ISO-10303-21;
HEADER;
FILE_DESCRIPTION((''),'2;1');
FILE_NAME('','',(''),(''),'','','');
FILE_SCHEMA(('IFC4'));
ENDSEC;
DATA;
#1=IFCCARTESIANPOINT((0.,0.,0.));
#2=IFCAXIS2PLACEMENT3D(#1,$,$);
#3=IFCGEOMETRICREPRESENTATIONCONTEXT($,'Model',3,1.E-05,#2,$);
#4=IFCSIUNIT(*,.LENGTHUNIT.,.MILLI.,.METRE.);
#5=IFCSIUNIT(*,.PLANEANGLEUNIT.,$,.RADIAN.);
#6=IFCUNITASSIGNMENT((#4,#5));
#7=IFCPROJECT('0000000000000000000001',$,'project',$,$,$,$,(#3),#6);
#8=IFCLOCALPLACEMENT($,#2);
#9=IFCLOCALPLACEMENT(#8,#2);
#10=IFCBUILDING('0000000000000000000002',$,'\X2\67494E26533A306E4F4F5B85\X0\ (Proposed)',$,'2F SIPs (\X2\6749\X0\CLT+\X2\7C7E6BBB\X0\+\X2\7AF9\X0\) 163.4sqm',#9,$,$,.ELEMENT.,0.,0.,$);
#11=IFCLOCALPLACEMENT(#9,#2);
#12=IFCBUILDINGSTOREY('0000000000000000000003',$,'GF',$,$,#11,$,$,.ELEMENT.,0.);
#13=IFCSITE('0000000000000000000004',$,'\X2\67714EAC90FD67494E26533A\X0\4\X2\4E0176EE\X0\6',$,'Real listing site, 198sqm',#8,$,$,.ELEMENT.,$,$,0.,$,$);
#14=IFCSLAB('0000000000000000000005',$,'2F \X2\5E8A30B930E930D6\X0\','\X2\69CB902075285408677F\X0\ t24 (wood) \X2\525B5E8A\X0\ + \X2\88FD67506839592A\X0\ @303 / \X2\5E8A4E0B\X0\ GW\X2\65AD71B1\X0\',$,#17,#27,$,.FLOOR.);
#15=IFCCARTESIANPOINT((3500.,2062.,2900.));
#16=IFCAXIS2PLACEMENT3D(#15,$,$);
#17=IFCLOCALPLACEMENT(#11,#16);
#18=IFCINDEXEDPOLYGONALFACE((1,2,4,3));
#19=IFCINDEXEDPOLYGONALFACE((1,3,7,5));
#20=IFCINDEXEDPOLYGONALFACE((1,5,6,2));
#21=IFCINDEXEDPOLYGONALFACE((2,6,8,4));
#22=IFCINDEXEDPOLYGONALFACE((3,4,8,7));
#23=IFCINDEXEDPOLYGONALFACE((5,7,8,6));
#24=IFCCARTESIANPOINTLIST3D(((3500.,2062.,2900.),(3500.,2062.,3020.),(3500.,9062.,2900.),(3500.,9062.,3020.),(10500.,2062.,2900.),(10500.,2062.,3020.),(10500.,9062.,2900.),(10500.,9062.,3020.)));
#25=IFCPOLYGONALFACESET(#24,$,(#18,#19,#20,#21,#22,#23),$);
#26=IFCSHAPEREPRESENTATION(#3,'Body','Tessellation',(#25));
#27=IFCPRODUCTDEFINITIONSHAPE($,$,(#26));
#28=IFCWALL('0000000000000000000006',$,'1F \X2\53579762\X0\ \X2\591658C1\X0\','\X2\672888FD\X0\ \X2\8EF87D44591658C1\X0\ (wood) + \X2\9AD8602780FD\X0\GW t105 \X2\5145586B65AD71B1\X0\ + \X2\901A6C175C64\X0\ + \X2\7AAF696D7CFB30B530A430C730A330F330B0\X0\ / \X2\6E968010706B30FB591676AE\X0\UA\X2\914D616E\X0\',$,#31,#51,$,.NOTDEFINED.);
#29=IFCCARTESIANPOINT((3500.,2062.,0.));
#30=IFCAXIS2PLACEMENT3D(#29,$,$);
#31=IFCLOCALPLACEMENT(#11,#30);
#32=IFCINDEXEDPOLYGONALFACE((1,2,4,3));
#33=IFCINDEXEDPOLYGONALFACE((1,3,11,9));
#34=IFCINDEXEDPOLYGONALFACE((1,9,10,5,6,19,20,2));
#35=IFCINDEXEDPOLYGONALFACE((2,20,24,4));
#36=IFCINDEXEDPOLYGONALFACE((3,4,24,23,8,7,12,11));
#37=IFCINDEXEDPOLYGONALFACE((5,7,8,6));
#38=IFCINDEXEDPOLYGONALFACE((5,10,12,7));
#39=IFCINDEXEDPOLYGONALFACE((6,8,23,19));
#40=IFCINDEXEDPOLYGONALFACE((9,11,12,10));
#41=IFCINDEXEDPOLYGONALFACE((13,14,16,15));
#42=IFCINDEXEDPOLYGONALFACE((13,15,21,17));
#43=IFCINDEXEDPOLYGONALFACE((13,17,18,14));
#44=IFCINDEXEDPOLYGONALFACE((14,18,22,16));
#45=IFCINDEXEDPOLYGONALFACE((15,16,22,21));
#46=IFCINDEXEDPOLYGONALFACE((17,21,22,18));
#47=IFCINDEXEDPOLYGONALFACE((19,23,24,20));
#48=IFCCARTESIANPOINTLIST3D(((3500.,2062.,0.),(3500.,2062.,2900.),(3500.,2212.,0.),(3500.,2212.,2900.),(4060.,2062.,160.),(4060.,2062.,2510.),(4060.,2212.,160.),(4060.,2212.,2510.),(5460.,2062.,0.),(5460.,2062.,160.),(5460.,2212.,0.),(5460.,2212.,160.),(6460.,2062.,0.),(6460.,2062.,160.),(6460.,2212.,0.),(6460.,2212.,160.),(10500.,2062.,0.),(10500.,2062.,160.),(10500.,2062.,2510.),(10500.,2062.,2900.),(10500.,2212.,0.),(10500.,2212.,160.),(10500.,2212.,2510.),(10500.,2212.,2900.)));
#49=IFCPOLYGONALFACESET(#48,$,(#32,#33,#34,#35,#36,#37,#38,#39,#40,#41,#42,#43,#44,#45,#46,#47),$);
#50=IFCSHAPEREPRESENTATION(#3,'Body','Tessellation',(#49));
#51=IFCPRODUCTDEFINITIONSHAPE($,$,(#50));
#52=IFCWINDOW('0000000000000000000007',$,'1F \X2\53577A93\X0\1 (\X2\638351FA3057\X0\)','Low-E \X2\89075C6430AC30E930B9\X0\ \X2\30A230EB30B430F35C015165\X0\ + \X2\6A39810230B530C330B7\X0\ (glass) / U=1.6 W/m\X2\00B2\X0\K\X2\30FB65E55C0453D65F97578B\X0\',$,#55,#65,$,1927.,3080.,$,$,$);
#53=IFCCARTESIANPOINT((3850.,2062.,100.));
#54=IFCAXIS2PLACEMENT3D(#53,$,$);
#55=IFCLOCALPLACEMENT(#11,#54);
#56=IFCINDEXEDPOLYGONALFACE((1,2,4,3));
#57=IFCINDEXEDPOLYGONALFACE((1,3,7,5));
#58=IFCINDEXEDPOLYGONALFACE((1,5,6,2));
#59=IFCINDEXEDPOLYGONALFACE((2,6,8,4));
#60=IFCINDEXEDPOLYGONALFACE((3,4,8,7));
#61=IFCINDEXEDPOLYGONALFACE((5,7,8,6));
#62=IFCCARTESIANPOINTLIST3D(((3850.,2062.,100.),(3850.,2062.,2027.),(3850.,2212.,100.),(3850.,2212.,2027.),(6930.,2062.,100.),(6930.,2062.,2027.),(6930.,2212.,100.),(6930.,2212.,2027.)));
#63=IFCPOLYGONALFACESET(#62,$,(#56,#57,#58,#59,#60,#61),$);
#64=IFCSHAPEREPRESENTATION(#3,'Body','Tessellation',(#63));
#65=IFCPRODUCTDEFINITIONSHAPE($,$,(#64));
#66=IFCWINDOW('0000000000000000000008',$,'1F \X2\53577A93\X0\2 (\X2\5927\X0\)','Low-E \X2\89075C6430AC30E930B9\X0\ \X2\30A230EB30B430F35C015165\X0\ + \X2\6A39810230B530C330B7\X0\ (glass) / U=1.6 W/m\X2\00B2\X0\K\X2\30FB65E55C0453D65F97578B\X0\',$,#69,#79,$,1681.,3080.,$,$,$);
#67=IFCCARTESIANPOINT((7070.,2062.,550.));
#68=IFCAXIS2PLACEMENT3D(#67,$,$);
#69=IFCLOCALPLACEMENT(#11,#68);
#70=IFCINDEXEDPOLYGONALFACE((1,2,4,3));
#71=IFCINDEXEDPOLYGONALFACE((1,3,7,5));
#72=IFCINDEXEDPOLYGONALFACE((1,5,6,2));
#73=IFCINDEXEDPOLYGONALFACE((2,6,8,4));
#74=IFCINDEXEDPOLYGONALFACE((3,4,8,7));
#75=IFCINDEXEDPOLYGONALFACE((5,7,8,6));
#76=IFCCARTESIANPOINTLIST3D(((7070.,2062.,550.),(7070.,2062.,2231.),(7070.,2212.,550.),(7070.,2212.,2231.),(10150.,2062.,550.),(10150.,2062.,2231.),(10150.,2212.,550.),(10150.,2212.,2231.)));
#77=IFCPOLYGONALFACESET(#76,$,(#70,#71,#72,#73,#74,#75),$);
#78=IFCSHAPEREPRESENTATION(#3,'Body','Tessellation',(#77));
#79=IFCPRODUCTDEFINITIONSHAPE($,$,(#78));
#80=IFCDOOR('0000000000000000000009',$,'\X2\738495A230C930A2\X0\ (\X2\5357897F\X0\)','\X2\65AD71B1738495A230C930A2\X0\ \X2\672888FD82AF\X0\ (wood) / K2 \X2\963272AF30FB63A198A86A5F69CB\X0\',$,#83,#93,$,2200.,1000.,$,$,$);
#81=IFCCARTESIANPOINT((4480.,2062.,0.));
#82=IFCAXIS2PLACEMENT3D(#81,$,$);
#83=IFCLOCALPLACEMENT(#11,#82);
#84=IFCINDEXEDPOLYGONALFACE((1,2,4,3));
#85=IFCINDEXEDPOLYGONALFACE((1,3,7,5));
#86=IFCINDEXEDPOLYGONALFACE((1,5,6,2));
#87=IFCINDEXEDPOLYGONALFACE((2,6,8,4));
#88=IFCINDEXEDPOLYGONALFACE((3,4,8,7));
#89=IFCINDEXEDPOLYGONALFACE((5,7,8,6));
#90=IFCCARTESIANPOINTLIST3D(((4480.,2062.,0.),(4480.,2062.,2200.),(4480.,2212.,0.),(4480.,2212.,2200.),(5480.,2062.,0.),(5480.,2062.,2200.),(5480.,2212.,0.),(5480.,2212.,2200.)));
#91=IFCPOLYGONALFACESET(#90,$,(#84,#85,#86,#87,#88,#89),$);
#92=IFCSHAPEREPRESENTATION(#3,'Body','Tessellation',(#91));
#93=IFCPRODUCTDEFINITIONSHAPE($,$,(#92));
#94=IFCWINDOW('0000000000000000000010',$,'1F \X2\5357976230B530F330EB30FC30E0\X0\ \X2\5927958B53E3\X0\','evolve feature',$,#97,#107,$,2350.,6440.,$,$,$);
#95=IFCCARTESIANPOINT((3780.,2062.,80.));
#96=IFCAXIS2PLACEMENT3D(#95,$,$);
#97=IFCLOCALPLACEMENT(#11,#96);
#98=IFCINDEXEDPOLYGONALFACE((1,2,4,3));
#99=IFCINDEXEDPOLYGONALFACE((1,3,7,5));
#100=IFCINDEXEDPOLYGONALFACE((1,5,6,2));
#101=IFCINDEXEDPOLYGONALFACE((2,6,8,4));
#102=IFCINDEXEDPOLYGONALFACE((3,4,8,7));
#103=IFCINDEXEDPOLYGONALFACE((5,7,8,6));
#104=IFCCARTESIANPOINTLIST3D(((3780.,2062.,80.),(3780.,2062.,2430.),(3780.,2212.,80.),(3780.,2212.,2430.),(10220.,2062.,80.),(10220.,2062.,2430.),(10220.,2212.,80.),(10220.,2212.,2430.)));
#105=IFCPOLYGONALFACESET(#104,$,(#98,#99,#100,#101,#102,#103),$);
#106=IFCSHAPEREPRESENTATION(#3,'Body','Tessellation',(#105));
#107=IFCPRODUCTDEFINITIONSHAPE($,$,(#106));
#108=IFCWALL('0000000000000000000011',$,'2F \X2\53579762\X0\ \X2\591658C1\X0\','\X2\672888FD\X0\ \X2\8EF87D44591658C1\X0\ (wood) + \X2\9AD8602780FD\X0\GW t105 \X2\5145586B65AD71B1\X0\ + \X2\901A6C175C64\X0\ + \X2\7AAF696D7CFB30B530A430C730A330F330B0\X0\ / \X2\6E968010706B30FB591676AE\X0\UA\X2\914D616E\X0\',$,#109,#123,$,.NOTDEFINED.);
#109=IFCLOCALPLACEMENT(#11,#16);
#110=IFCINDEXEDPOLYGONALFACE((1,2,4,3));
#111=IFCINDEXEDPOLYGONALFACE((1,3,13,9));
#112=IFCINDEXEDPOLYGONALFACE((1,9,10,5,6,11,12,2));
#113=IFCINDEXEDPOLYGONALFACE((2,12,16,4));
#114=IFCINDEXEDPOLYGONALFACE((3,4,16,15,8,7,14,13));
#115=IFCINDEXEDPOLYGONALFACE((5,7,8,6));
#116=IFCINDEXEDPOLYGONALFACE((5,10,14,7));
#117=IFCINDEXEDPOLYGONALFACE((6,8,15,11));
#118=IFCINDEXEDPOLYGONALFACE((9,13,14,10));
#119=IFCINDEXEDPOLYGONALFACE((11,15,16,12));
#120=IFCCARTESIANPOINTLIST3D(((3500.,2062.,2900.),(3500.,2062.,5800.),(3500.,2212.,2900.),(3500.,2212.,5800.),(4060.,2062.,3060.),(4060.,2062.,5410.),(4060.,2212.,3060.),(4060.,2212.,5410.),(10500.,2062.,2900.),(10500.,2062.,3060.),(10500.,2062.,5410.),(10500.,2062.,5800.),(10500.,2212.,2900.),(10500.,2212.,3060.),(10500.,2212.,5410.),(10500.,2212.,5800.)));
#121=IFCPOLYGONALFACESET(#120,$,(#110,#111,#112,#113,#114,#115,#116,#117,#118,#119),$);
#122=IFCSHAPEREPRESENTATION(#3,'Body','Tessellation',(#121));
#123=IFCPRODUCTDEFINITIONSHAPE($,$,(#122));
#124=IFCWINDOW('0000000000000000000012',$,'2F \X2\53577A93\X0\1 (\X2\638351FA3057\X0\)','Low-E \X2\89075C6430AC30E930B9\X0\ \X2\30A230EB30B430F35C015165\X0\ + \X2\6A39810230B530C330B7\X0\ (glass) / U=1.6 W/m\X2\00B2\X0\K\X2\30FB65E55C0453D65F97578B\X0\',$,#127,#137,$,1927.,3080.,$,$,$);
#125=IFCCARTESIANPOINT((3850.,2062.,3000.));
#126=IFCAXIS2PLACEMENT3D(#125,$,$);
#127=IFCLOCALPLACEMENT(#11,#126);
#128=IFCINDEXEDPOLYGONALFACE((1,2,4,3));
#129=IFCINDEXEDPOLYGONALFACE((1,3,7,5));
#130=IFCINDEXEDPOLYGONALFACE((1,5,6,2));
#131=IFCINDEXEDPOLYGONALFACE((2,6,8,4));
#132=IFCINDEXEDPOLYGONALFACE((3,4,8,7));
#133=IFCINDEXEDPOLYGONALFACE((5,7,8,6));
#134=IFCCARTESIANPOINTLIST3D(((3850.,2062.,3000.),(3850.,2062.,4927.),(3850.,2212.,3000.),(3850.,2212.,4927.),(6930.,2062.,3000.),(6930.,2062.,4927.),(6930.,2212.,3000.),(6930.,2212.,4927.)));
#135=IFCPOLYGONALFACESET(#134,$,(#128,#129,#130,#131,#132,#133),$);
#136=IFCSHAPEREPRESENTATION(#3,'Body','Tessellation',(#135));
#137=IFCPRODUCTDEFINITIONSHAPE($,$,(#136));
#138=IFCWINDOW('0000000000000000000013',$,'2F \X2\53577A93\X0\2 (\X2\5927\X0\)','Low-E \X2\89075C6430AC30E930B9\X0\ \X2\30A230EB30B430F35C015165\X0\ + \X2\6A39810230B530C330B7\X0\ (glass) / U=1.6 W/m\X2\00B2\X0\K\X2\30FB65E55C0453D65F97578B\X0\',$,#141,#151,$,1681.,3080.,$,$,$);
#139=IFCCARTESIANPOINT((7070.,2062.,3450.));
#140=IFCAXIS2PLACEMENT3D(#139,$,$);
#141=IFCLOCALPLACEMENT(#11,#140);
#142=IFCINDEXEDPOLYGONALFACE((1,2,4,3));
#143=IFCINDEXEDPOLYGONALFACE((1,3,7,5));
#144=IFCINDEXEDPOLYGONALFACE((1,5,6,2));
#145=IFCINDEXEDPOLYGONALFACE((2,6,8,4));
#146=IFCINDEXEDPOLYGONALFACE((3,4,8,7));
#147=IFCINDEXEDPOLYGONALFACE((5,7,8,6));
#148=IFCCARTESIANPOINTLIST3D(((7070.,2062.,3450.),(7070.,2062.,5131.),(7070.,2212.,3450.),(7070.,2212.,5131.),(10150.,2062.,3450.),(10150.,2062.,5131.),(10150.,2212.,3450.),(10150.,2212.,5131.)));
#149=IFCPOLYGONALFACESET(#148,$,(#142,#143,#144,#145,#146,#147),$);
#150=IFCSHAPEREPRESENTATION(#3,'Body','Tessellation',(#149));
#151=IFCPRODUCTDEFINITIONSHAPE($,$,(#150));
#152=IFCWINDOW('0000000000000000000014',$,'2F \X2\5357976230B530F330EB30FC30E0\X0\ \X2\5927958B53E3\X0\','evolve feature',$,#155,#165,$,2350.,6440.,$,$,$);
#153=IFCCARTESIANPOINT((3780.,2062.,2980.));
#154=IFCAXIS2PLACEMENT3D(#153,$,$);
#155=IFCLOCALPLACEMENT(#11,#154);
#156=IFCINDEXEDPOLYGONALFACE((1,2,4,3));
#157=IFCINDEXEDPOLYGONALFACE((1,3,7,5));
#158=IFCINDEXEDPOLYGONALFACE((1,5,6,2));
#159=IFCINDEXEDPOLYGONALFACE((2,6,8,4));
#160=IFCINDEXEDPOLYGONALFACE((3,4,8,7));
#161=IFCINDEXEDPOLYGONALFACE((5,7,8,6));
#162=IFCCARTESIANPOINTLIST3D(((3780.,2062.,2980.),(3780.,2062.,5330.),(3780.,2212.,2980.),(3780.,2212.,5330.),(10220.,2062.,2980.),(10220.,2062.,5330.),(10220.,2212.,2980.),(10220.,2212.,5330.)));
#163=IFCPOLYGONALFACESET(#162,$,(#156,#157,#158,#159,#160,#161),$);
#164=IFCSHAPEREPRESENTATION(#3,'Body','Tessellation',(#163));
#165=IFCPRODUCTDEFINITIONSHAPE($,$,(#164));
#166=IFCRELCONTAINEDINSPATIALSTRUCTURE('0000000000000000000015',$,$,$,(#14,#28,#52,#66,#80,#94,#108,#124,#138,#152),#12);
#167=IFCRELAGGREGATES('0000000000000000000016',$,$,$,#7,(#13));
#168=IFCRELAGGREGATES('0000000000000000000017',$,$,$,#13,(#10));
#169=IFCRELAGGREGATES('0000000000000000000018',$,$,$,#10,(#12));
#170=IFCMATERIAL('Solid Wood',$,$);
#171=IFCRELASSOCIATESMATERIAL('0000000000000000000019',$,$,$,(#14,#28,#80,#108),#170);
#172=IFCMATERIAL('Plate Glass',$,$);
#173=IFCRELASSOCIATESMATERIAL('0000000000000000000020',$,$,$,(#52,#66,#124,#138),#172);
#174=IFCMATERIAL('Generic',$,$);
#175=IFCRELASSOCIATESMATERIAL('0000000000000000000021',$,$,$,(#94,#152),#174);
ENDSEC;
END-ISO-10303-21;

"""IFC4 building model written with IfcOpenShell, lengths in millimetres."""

from ifc_helpers import new_model, si_unit, frame, frame_2d, origin, place, context, project, spatial, rectangle, extrude, material, element, fill, save


model = new_model("IFC4")

# Units and contexts
model_context = context("Model", 3, precision=1e-05, world=origin())
ifc_project = project(units=[si_unit("LENGTHUNIT", "METRE", prefix="MILLI"), si_unit("PLANEANGLEUNIT", "RADIAN")], contexts=[model_context])

# Site, building, storey
site_placement = place(None, origin())
site = spatial("IfcSite", under=ifc_project, at=site_placement, Name="東京都杉並区4丁目6", ObjectType="Real listing site, 198sqm", CompositionType="ELEMENT", RefElevation=0.0)
building_placement = place(site_placement, origin())
building = spatial("IfcBuilding", under=site, at=building_placement, Name="杉並区の住宅 (Proposed)", ObjectType="2F SIPs (杉CLT+籾殻+竹) 163.4sqm", CompositionType="ELEMENT", ElevationOfRefHeight=0.0, ElevationOfTerrain=0.0)
storey_placement = place(building_placement, origin())
storey = spatial("IfcBuildingStorey", under=building, at=storey_placement, Name="GF", CompositionType="ELEMENT", Elevation=0.0)

# Slab
ifc_material_1 = material(Name="Solid Wood")
slab_1_placement = place(storey_placement, frame((3500.0, 2062.0, 2900.0)))
element("IfcSlab", 1, at=slab_1_placement, inside=storey, material=ifc_material_1, Name="2F 床スラブ", Description="構造用合板 t24 (wood) 剛床 + 製材根太 @303 / 床下 GW断熱", PredefinedType="FLOOR", context=model_context, shape_type="SweptSolid", body=[
    extrude(rectangle(XDim=7000.0, YDim=7000.0, at=frame_2d((3500.0, 3500.0))), frame((3500.0, 2062.0, 2900.0)), (0.0, 0.0, 1.0), 120.0),
])
ifc_material_2 = material(Name="Generic")

# Wall, openings, windows, door
wall_1_placement = place(storey_placement, frame((3500.0, 2062.0, 0.0)))
wall_1 = element("IfcWall", 2, at=wall_1_placement, inside=storey, material=ifc_material_1, Name="1F 南面 外壁", Description="木製 軸組外壁 (wood) + 高性能GW t105 充填断熱 + 通気層 + 窯業系サイディング / 準耐火・外皮UA配慮", PredefinedType="NOTDEFINED", context=model_context, shape_type="SweptSolid", body=[
    extrude(rectangle(XDim=7000.0, YDim=150.0, at=frame_2d((3500.0, 75.0))), frame((3500.0, 2062.0, 0.0)), (0.0, 0.0, 1.0), 2900.0),
])
opening_1_placement = place(storey_placement, frame((3850.0, 2062.0, 100.0)))
opening_1 = element("IfcOpeningElement", 3, at=opening_1_placement, cuts=wall_1, PredefinedType="NOTDEFINED", context=model_context, shape_type="SweptSolid", body=[
    extrude(rectangle(XDim=3080.0, YDim=150.0, at=frame_2d((1540.0, 75.0))), frame((3850.0, 2062.0, 100.0)), (0.0, 0.0, 1.0), 1927.0),
])
opening_2_placement = place(storey_placement, frame((7070.0, 2062.0, 550.0)))
opening_2 = element("IfcOpeningElement", 4, at=opening_2_placement, cuts=wall_1, PredefinedType="NOTDEFINED", context=model_context, shape_type="SweptSolid", body=[
    extrude(rectangle(XDim=3080.0, YDim=150.0, at=frame_2d((1540.0, 75.0))), frame((7070.0, 2062.0, 550.0)), (0.0, 0.0, 1.0), 1681.0),
])
opening_3_placement = place(storey_placement, frame((4480.0, 2062.0, 0.0)))
opening_3 = element("IfcOpeningElement", 5, at=opening_3_placement, cuts=wall_1, PredefinedType="NOTDEFINED", context=model_context, shape_type="SweptSolid", body=[
    extrude(rectangle(XDim=1000.0, YDim=150.0, at=frame_2d((500.0, 75.0))), frame((4480.0, 2062.0, 0.0)), (0.0, 0.0, 1.0), 2200.0),
])
opening_4_placement = place(storey_placement, frame((3780.0, 2062.0, 80.0)))
opening_4 = element("IfcOpeningElement", 6, at=opening_4_placement, cuts=wall_1, PredefinedType="NOTDEFINED", context=model_context, shape_type="SweptSolid", body=[
    extrude(rectangle(XDim=6440.0, YDim=150.0, at=frame_2d((3220.0, 75.0))), frame((3780.0, 2062.0, 80.0)), (0.0, 0.0, 1.0), 2350.0),
])
ifc_material_3 = material(Name="Plate Glass")
window_1_placement = place(storey_placement, frame((3850.0, 2062.0, 100.0)))
window_1 = element("IfcWindow", 7, at=window_1_placement, inside=storey, material=ifc_material_3, Name="1F 南窓1 (掃出し)", Description="Low-E 複層ガラス アルゴン封入 + 樹脂サッシ (glass) / U=1.6 W/m²K・日射取得型", OverallHeight=1927.0, OverallWidth=3080.0, context=model_context, shape_type="SweptSolid", body=[
    extrude(rectangle(XDim=3080.0, YDim=150.0, at=frame_2d((1540.0, 75.0))), frame((3850.0, 2062.0, 100.0)), (0.0, 0.0, 1.0), 1927.0),
])
fill(opening_1, window_1)
window_2_placement = place(storey_placement, frame((7070.0, 2062.0, 550.0)))
window_2 = element("IfcWindow", 8, at=window_2_placement, inside=storey, material=ifc_material_3, Name="1F 南窓2 (大)", Description="Low-E 複層ガラス アルゴン封入 + 樹脂サッシ (glass) / U=1.6 W/m²K・日射取得型", OverallHeight=1681.0, OverallWidth=3080.0, context=model_context, shape_type="SweptSolid", body=[
    extrude(rectangle(XDim=3080.0, YDim=150.0, at=frame_2d((1540.0, 75.0))), frame((7070.0, 2062.0, 550.0)), (0.0, 0.0, 1.0), 1681.0),
])
fill(opening_2, window_2)
door_placement = place(storey_placement, frame((4480.0, 2062.0, 0.0)))
door = element("IfcDoor", 9, at=door_placement, inside=storey, material=ifc_material_1, Name="玄関ドア (南西)", Description="断熱玄関ドア 木製芯 (wood) / K2 防犯・採風機構", OverallHeight=2200.0, OverallWidth=1000.0, context=model_context, shape_type="SweptSolid", body=[
    extrude(rectangle(XDim=1000.0, YDim=150.0, at=frame_2d((500.0, 75.0))), frame((4480.0, 2062.0, 0.0)), (0.0, 0.0, 1.0), 2200.0),
])
fill(opening_3, door)
window_3_placement = place(storey_placement, frame((3780.0, 2062.0, 80.0)))
window_3 = element("IfcWindow", 10, at=window_3_placement, inside=storey, material=ifc_material_2, Name="1F 南面サンルーム 大開口", Description="evolve feature", OverallHeight=2350.0, OverallWidth=6440.0, context=model_context, shape_type="SweptSolid", body=[
    extrude(rectangle(XDim=6440.0, YDim=150.0, at=frame_2d((3220.0, 75.0))), frame((3780.0, 2062.0, 80.0)), (0.0, 0.0, 1.0), 2350.0),
])
fill(opening_4, window_3)

# Wall, openings, windows
wall_2_placement = place(storey_placement, frame((3500.0, 2062.0, 2900.0)))
wall_2 = element("IfcWall", 11, at=wall_2_placement, inside=storey, material=ifc_material_1, Name="2F 南面 外壁", Description="木製 軸組外壁 (wood) + 高性能GW t105 充填断熱 + 通気層 + 窯業系サイディング / 準耐火・外皮UA配慮", PredefinedType="NOTDEFINED", context=model_context, shape_type="SweptSolid", body=[
    extrude(rectangle(XDim=7000.0, YDim=150.0, at=frame_2d((3500.0, 75.0))), frame((3500.0, 2062.0, 2900.0)), (0.0, 0.0, 1.0), 2900.0),
])
opening_5_placement = place(storey_placement, frame((3850.0, 2062.0, 3000.0)))
opening_5 = element("IfcOpeningElement", 12, at=opening_5_placement, cuts=wall_2, PredefinedType="NOTDEFINED", context=model_context, shape_type="SweptSolid", body=[
    extrude(rectangle(XDim=3080.0, YDim=150.0, at=frame_2d((1540.0, 75.0))), frame((3850.0, 2062.0, 3000.0)), (0.0, 0.0, 1.0), 1927.0),
])
opening_6_placement = place(storey_placement, frame((7070.0, 2062.0, 3450.0)))
opening_6 = element("IfcOpeningElement", 13, at=opening_6_placement, cuts=wall_2, PredefinedType="NOTDEFINED", context=model_context, shape_type="SweptSolid", body=[
    extrude(rectangle(XDim=3080.0, YDim=150.0, at=frame_2d((1540.0, 75.0))), frame((7070.0, 2062.0, 3450.0)), (0.0, 0.0, 1.0), 1681.0),
])
opening_7_placement = place(storey_placement, frame((3780.0, 2062.0, 2980.0)))
opening_7 = element("IfcOpeningElement", 14, at=opening_7_placement, cuts=wall_2, PredefinedType="NOTDEFINED", context=model_context, shape_type="SweptSolid", body=[
    extrude(rectangle(XDim=6440.0, YDim=150.0, at=frame_2d((3220.0, 75.0))), frame((3780.0, 2062.0, 2980.0)), (0.0, 0.0, 1.0), 2350.0),
])
window_4_placement = place(storey_placement, frame((3850.0, 2062.0, 3000.0)))
window_4 = element("IfcWindow", 15, at=window_4_placement, inside=storey, material=ifc_material_3, Name="2F 南窓1 (掃出し)", Description="Low-E 複層ガラス アルゴン封入 + 樹脂サッシ (glass) / U=1.6 W/m²K・日射取得型", OverallHeight=1927.0, OverallWidth=3080.0, context=model_context, shape_type="SweptSolid", body=[
    extrude(rectangle(XDim=3080.0, YDim=150.0, at=frame_2d((1540.0, 75.0))), frame((3850.0, 2062.0, 3000.0)), (0.0, 0.0, 1.0), 1927.0),
])
fill(opening_5, window_4)
window_5_placement = place(storey_placement, frame((7070.0, 2062.0, 3450.0)))
window_5 = element("IfcWindow", 16, at=window_5_placement, inside=storey, material=ifc_material_3, Name="2F 南窓2 (大)", Description="Low-E 複層ガラス アルゴン封入 + 樹脂サッシ (glass) / U=1.6 W/m²K・日射取得型", OverallHeight=1681.0, OverallWidth=3080.0, context=model_context, shape_type="SweptSolid", body=[
    extrude(rectangle(XDim=3080.0, YDim=150.0, at=frame_2d((1540.0, 75.0))), frame((7070.0, 2062.0, 3450.0)), (0.0, 0.0, 1.0), 1681.0),
])
fill(opening_6, window_5)
window_6_placement = place(storey_placement, frame((3780.0, 2062.0, 2980.0)))
window_6 = element("IfcWindow", 17, at=window_6_placement, inside=storey, material=ifc_material_2, Name="2F 南面サンルーム 大開口", Description="evolve feature", OverallHeight=2350.0, OverallWidth=6440.0, context=model_context, shape_type="SweptSolid", body=[
    extrude(rectangle(XDim=6440.0, YDim=150.0, at=frame_2d((3220.0, 75.0))), frame((3780.0, 2062.0, 2980.0)), (0.0, 0.0, 1.0), 2350.0),
])
fill(opening_7, window_6)

save(model, "model.ifc")
